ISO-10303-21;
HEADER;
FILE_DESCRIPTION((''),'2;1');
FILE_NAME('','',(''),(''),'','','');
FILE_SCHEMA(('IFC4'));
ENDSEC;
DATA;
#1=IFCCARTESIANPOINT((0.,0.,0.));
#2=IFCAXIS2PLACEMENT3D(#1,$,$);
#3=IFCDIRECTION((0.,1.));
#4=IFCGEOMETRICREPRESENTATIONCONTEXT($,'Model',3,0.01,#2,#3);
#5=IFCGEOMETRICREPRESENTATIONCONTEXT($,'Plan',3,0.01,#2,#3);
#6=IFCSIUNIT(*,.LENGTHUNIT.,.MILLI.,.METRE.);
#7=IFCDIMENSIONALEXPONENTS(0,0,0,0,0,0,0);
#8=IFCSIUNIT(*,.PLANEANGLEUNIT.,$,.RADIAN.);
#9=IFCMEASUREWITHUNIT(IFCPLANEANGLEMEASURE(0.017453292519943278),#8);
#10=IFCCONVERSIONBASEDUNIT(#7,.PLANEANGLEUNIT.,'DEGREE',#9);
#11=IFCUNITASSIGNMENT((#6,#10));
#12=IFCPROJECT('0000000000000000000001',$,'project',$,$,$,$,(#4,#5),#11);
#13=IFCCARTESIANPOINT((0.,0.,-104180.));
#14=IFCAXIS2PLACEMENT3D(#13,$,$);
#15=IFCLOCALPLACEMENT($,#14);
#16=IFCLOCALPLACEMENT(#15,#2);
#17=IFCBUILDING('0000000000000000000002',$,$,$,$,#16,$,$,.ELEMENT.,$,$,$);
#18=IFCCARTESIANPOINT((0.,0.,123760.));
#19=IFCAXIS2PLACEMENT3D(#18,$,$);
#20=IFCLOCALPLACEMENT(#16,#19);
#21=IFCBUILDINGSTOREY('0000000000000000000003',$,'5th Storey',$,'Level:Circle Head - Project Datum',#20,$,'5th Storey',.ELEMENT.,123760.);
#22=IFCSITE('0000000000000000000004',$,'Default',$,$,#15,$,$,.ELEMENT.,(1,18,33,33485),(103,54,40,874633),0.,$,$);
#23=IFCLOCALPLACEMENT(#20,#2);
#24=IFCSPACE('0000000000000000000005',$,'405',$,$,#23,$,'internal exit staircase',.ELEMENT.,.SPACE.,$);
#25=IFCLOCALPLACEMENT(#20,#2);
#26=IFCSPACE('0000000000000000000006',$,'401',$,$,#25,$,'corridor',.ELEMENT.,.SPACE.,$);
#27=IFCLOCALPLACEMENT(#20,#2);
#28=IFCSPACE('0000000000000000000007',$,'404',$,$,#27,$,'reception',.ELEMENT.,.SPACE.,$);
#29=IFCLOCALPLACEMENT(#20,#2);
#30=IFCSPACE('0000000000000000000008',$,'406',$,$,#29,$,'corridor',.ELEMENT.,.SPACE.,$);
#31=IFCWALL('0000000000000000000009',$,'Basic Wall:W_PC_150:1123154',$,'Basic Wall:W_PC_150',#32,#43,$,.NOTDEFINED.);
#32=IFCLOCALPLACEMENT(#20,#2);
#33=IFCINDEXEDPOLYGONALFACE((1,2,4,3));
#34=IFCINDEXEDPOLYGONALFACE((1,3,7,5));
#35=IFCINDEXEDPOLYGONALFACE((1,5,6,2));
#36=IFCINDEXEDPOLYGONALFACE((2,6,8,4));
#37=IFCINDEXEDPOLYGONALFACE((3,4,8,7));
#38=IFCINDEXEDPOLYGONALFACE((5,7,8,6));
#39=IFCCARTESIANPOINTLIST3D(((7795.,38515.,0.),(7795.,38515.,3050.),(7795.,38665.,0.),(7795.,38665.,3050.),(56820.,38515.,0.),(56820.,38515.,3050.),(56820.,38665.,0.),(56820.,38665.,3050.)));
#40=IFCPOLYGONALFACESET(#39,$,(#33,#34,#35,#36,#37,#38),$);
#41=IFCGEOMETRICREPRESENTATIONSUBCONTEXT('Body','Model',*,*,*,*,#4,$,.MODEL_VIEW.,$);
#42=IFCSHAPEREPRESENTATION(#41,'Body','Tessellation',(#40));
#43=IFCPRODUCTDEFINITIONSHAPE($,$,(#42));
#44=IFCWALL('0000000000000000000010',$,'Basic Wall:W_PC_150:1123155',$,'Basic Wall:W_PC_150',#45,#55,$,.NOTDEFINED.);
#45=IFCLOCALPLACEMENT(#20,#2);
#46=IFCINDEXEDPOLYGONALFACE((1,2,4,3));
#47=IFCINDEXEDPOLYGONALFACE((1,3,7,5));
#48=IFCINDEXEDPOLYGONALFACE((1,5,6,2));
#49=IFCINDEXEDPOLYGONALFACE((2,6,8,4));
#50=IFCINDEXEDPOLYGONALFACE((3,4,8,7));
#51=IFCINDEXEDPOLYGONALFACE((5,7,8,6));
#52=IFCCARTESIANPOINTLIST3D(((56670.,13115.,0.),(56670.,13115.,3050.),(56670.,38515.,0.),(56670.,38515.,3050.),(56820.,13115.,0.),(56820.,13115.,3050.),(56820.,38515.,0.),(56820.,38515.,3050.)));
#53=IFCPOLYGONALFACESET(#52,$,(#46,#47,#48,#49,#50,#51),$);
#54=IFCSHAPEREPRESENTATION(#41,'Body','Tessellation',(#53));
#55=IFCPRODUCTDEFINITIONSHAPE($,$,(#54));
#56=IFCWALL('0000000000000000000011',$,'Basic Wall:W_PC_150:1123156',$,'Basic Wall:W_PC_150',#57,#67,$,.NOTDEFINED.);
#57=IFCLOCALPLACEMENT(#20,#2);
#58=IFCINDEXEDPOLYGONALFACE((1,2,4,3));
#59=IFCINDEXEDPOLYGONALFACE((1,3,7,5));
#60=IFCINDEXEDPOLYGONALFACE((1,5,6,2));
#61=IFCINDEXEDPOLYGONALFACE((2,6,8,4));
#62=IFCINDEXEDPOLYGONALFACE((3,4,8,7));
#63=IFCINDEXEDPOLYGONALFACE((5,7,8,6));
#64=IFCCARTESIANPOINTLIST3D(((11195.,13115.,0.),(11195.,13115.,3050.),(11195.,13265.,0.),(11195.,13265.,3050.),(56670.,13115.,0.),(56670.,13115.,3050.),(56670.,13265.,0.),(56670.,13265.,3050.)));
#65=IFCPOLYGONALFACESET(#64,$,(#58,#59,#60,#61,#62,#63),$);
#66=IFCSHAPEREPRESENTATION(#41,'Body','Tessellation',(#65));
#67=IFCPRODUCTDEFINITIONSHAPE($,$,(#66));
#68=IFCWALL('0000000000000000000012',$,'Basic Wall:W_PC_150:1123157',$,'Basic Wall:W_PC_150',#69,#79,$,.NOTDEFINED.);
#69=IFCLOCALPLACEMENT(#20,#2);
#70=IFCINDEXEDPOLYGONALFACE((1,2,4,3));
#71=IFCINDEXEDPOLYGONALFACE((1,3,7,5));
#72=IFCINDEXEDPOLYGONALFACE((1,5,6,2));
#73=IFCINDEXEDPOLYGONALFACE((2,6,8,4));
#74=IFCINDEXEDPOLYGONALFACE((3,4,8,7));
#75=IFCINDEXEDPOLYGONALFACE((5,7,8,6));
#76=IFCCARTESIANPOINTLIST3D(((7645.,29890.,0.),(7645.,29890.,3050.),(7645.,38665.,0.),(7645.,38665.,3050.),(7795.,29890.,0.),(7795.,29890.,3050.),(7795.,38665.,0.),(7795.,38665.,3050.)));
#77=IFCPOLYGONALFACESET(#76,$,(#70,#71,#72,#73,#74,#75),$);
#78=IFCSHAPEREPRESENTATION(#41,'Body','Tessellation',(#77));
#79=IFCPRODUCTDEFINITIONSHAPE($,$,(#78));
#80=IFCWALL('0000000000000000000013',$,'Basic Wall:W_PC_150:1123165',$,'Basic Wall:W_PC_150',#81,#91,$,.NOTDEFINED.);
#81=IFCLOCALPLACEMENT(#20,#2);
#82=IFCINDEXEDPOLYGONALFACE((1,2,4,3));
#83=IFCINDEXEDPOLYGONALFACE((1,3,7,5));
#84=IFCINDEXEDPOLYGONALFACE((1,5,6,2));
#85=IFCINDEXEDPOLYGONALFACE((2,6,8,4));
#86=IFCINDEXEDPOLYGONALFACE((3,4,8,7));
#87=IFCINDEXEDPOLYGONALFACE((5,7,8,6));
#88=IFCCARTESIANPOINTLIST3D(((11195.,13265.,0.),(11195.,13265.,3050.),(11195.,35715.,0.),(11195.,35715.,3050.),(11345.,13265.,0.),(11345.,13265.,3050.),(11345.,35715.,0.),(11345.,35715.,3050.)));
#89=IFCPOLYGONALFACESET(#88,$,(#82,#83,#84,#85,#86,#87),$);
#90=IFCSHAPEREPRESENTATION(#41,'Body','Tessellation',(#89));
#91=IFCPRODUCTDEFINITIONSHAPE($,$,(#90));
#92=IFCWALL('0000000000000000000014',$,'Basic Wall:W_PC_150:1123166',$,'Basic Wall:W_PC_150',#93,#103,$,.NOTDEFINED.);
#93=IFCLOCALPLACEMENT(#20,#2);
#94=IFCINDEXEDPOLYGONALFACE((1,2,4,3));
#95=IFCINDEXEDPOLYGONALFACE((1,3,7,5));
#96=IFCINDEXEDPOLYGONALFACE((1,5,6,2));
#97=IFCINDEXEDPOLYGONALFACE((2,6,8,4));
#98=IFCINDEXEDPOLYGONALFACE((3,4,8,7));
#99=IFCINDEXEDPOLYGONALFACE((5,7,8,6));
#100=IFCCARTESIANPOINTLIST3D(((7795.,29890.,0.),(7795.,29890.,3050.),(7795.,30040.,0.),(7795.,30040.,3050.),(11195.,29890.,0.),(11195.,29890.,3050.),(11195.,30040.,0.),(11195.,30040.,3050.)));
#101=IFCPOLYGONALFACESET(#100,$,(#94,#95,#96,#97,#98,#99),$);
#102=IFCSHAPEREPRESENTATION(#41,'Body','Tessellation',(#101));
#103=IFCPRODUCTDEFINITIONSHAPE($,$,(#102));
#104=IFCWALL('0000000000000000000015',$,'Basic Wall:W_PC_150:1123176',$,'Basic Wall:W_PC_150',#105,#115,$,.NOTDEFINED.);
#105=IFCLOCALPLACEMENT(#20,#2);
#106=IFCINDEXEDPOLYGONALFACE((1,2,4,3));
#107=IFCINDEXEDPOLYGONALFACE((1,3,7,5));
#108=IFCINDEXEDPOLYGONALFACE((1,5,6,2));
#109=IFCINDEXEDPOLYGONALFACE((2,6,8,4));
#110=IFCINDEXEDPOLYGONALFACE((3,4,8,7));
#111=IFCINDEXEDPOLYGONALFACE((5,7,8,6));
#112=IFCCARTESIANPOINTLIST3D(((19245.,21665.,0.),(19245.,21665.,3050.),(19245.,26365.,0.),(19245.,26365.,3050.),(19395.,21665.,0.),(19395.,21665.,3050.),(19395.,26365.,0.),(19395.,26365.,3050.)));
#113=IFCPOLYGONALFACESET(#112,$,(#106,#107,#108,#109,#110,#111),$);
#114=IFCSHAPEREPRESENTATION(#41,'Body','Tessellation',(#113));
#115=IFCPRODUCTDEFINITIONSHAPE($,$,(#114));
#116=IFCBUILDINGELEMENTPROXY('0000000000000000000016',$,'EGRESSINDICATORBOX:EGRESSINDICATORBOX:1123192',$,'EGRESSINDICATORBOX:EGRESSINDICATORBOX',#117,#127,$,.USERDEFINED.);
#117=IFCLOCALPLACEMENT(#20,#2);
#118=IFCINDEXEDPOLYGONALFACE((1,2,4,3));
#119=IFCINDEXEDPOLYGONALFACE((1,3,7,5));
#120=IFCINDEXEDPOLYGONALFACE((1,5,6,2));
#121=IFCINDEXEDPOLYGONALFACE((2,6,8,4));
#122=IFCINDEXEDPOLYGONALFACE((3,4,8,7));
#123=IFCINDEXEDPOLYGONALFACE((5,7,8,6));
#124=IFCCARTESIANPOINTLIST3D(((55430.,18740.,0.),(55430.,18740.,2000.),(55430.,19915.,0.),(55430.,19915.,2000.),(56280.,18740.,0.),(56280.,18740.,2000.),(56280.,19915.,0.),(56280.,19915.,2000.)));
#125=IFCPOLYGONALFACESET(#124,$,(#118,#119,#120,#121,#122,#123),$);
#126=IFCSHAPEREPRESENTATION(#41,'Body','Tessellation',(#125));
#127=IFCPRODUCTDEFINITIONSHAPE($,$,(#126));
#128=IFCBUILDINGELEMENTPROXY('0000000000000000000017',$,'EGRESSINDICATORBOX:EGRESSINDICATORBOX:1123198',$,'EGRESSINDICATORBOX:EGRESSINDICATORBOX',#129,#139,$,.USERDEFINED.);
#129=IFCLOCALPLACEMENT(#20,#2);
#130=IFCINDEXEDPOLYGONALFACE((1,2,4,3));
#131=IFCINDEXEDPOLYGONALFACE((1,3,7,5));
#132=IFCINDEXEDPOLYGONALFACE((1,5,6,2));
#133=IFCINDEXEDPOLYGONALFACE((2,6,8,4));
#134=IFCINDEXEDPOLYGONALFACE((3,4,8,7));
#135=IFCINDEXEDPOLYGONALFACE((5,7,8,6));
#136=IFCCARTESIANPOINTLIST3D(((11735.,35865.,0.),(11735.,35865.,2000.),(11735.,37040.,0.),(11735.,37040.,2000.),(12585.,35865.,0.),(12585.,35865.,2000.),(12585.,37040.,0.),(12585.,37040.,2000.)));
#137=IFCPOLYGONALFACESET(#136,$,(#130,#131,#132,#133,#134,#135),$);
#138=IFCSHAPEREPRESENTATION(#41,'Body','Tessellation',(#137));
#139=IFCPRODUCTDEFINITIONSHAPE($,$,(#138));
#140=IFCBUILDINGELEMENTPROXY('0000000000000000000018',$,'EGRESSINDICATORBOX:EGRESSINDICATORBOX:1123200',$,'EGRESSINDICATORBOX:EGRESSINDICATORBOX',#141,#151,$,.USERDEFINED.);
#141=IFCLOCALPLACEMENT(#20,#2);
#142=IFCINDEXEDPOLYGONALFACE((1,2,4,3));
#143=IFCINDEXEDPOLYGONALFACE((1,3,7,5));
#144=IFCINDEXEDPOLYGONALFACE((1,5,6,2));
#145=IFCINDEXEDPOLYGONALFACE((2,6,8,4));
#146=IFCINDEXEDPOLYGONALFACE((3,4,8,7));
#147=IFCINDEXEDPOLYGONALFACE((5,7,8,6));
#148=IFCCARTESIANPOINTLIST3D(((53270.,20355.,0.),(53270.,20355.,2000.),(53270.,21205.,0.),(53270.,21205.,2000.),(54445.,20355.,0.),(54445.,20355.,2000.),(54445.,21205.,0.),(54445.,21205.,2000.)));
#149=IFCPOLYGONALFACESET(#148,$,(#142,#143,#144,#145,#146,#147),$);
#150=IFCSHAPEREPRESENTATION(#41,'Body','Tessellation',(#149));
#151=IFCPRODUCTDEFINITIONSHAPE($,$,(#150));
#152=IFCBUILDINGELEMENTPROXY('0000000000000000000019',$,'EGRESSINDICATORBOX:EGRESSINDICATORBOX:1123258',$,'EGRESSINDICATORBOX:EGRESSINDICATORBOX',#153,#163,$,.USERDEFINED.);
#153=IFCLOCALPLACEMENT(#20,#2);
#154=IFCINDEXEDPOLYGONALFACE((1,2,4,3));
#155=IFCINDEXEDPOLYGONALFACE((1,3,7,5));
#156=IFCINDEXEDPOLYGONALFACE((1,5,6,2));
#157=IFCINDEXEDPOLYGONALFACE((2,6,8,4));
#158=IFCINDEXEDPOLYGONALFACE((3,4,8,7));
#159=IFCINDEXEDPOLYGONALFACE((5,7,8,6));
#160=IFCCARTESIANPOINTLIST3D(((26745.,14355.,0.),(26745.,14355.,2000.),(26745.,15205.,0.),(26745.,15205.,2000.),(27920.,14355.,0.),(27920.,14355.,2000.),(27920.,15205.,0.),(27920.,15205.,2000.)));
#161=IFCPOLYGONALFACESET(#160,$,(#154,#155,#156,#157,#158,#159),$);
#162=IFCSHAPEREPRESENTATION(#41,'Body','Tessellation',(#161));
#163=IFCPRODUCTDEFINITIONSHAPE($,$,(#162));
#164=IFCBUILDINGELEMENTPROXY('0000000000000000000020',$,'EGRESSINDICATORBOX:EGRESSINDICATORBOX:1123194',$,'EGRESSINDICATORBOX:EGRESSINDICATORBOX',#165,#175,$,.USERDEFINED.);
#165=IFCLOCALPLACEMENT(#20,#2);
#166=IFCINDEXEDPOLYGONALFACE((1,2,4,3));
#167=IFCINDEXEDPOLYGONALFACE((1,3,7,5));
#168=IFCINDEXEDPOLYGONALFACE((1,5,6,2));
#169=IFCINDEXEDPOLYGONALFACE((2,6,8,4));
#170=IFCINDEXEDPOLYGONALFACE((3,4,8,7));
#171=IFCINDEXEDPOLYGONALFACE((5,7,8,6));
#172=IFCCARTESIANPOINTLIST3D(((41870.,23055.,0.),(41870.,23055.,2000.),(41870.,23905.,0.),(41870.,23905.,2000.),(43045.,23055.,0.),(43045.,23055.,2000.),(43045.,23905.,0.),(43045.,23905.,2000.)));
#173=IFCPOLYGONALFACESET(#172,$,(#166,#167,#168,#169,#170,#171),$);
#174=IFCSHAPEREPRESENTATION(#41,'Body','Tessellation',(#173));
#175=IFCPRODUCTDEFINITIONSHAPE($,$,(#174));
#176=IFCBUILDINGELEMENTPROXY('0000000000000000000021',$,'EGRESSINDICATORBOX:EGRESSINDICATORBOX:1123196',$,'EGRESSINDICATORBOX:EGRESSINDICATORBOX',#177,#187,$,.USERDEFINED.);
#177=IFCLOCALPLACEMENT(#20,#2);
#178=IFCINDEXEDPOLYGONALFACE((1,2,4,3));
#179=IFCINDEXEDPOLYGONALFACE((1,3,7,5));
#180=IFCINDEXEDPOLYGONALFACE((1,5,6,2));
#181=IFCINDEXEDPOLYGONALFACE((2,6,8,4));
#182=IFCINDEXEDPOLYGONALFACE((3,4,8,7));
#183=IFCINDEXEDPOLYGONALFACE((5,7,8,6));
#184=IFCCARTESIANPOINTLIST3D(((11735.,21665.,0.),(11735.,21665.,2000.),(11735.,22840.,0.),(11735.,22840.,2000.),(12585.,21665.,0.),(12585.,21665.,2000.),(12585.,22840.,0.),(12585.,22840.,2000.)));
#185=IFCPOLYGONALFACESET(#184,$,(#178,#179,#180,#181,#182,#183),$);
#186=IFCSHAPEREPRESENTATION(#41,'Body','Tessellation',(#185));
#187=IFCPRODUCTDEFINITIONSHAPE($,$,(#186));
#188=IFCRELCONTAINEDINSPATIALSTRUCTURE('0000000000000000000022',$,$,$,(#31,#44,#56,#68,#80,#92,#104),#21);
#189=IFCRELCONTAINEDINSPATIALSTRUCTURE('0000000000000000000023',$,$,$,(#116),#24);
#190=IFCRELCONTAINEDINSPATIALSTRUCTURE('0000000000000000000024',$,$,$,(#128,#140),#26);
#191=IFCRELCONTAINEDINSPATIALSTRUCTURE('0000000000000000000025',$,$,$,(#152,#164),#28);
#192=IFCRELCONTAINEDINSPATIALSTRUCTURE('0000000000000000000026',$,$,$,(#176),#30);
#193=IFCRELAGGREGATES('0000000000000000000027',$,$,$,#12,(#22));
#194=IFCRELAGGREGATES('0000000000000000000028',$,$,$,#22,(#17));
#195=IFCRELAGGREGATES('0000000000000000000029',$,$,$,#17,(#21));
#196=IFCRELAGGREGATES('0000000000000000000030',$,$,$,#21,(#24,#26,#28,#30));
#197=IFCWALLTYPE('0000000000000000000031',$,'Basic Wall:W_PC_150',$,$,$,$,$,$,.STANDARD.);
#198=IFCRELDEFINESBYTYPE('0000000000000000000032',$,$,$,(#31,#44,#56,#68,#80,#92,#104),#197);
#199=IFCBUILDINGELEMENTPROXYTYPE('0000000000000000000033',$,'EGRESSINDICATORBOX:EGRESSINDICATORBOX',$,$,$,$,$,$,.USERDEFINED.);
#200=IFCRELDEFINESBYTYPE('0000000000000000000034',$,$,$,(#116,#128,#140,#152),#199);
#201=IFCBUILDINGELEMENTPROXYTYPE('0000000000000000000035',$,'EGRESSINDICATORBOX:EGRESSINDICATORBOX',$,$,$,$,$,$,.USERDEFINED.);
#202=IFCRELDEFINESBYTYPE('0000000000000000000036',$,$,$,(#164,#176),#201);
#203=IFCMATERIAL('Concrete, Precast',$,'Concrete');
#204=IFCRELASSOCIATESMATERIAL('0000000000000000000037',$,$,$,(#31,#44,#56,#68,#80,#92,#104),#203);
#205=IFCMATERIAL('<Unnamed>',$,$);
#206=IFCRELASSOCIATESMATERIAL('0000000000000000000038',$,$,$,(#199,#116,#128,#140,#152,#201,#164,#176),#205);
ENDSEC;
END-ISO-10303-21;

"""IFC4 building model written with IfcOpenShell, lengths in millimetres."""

from ifc_helpers import new_model, entity, si_unit, converted_unit, direction, frame, origin, place, context, subcontext, project, spatial, indexed_curve, outline, extrude, source, transform, mapped, material, type_object, type_shapes, element, save


model = new_model("IFC4")

# Units and contexts
model_context = context("Model", 3, precision=0.01, world=origin(), true_north=direction((0.0, 1.0)))
plan_context = context("Plan", 3, precision=0.01, world=origin(), true_north=direction((0.0, 1.0)))
body_context = subcontext(model_context, "Body", "Model", "MODEL_VIEW")
ifc_project = project(units=[si_unit("LENGTHUNIT", "METRE", prefix="MILLI"), converted_unit("PLANEANGLEUNIT", "DEGREE", entity("IfcPlaneAngleMeasure", 0.017453292519943278), si_unit("PLANEANGLEUNIT", "RADIAN"), dimensions=[0, 0, 0, 0, 0, 0, 0])], contexts=[model_context, plan_context])

# Site, building, storey
site_placement = place(None, frame((0.0, 0.0, -104180.0)))
site = spatial("IfcSite", under=ifc_project, at=site_placement, Name="Default", CompositionType="ELEMENT", RefLatitude=(1, 18, 33, 33485), RefLongitude=(103, 54, 40, 874633), RefElevation=0.0)
building_placement = place(site_placement, origin())
building = spatial("IfcBuilding", under=site, at=building_placement, CompositionType="ELEMENT")
storey_placement = place(building_placement, frame((0.0, 0.0, 123760.0)))
storey = spatial("IfcBuildingStorey", under=building, at=storey_placement, Name="5th Storey", ObjectType="Level:Circle Head - Project Datum", LongName="5th Storey", CompositionType="ELEMENT", Elevation=123760.0)

# Shared definitions
ifc_material_1 = material(Name="Concrete, Precast", Category="Concrete")

# Walls
wall_type = type_object("IfcWallType", Name="Basic Wall:W_PC_150", PredefinedType="STANDARD")
wall_1_placement = place(storey_placement, frame((56820.0, 38590.0, 0.0), z_axis=(0.0, 0.0, 1.0), x_axis=(-1.0, 0.0, 0.0)))
element("IfcWall", 1, at=wall_1_placement, inside=storey, type_object=wall_type, material=ifc_material_1, Name="Basic Wall:W_PC_150:1123154", ObjectType="Basic Wall:W_PC_150", PredefinedType="NOTDEFINED", context=body_context, shape_type="SweptSolid", body=[
    extrude(outline(indexed_curve([(49025.0, 75.0), (0.0, 75.0), (0.0, -75.0), (49025.0, -75.0), (49025.0, 75.0)], self_intersect=False)), origin(), (0.0, 0.0, 1.0), 3050.0),
])
wall_2_placement = place(storey_placement, frame((56745.0, 13115.0, 0.0), z_axis=(0.0, 0.0, 1.0), x_axis=(0.0, 1.0, 0.0)))
element("IfcWall", 2, at=wall_2_placement, inside=storey, type_object=wall_type, material=ifc_material_1, Name="Basic Wall:W_PC_150:1123155", ObjectType="Basic Wall:W_PC_150", PredefinedType="NOTDEFINED", context=body_context, shape_type="SweptSolid", body=[
    extrude(outline(indexed_curve([(25400.0, 75.0), (0.0, 75.0), (0.0, -75.0), (25400.0, -75.0), (25400.0, 75.0)], self_intersect=False)), origin(), (0.0, 0.0, 1.0), 3050.0),
])
wall_3_placement = place(storey_placement, frame((11195.0, 13190.0, 0.0)))
element("IfcWall", 3, at=wall_3_placement, inside=storey, type_object=wall_type, material=ifc_material_1, Name="Basic Wall:W_PC_150:1123156", ObjectType="Basic Wall:W_PC_150", PredefinedType="NOTDEFINED", context=body_context, shape_type="SweptSolid", body=[
    extrude(outline(indexed_curve([(45475.0, 75.0), (0.0, 75.0), (0.0, -75.0), (45475.0, -75.0), (45475.0, 75.0)], self_intersect=False)), origin(), (0.0, 0.0, 1.0), 3050.0),
])
wall_4_placement = place(storey_placement, frame((7720.0, 38665.0, 0.0), z_axis=(0.0, 0.0, 1.0), x_axis=(0.0, -1.0, 0.0)))
element("IfcWall", 4, at=wall_4_placement, inside=storey, type_object=wall_type, material=ifc_material_1, Name="Basic Wall:W_PC_150:1123157", ObjectType="Basic Wall:W_PC_150", PredefinedType="NOTDEFINED", context=body_context, shape_type="SweptSolid", body=[
    extrude(outline(indexed_curve([(8775.0, 75.0), (0.0, 75.0), (0.0, -75.0), (8775.0, -75.0), (8775.0, 75.0)], self_intersect=False)), origin(), (0.0, 0.0, 1.0), 3050.0),
])
wall_5_placement = place(storey_placement, frame((11270.0, 35715.0, 0.0), z_axis=(0.0, 0.0, 1.0), x_axis=(0.0, -1.0, 0.0)))
element("IfcWall", 5, at=wall_5_placement, inside=storey, type_object=wall_type, material=ifc_material_1, Name="Basic Wall:W_PC_150:1123165", ObjectType="Basic Wall:W_PC_150", PredefinedType="NOTDEFINED", context=body_context, shape_type="SweptSolid", body=[
    extrude(outline(indexed_curve([(22450.0, 75.0), (0.0, 75.0), (0.0, -75.0), (22450.0, -75.0), (22450.0, 75.0)], self_intersect=False)), origin(), (0.0, 0.0, 1.0), 3050.0),
])
wall_6_placement = place(storey_placement, frame((7795.0, 29965.0, 0.0)))
element("IfcWall", 6, at=wall_6_placement, inside=storey, type_object=wall_type, material=ifc_material_1, Name="Basic Wall:W_PC_150:1123166", ObjectType="Basic Wall:W_PC_150", PredefinedType="NOTDEFINED", context=body_context, shape_type="SweptSolid", body=[
    extrude(outline(indexed_curve([(3400.0, 75.0), (0.0, 75.0), (0.0, -75.0), (3400.0, -75.0), (3400.0, 75.0)], self_intersect=False)), origin(), (0.0, 0.0, 1.0), 3050.0),
])
wall_7_placement = place(storey_placement, frame((19320.0, 21665.0, 0.0), z_axis=(0.0, 0.0, 1.0), x_axis=(0.0, 1.0, 0.0)))
element("IfcWall", 7, at=wall_7_placement, inside=storey, type_object=wall_type, material=ifc_material_1, Name="Basic Wall:W_PC_150:1123176", ObjectType="Basic Wall:W_PC_150", PredefinedType="NOTDEFINED", context=body_context, shape_type="SweptSolid", body=[
    extrude(outline(indexed_curve([(4700.0, 75.0), (0.0, 75.0), (0.0, -75.0), (4700.0, -75.0), (4700.0, 75.0)], self_intersect=False)), origin(), (0.0, 0.0, 1.0), 3050.0),
])

# Shared definitions
space_1_placement = place(storey_placement, origin())
space_1 = spatial("IfcSpace", under=storey, at=space_1_placement, Name="405", LongName="internal exit staircase", CompositionType="ELEMENT", PredefinedType="SPACE")

# Building element proxy
ifc_material_2 = material(Name="<Unnamed>")
building_element_proxy_type_1 = type_object("IfcBuildingElementProxyType", Name="EGRESSINDICATORBOX:EGRESSINDICATORBOX", PredefinedType="USERDEFINED", material=ifc_material_2)
shared_shape_1 = source(origin(), body_context, "Body", "SweptSolid", [
    extrude(outline(indexed_curve([(-587.5, -425.0), (587.5, -425.0), (587.5, 425.0), (-587.5, 425.0), (-587.5, -425.0)], self_intersect=False)), frame((0.0, 0.0, 0.0), z_axis=(0.0, 0.0, 1.0), x_axis=(0.0, 1.0, 0.0)), (0.0, 0.0, 1.0), 2000.0),
])
type_shapes(building_element_proxy_type_1, [shared_shape_1])
proxy_1_placement = place(space_1_placement, frame((55855.0, 19327.5, 0.0)))
element("IfcBuildingElementProxy", 8, at=proxy_1_placement, inside=space_1, type_object=building_element_proxy_type_1, material=ifc_material_2, Name="EGRESSINDICATORBOX:EGRESSINDICATORBOX:1123192", ObjectType="EGRESSINDICATORBOX:EGRESSINDICATORBOX", PredefinedType="USERDEFINED", context=body_context, shape_type="MappedRepresentation", body=[
    mapped(shared_shape_1, transform((0.0, 0.0, 0.0), scale=1.0)),
])

# Shared definitions
space_2_placement = place(storey_placement, origin())
space_2 = spatial("IfcSpace", under=storey, at=space_2_placement, Name="401", LongName="corridor", CompositionType="ELEMENT", PredefinedType="SPACE")

# Building element proxies
for number, where, z_axis, x_axis, name in (
    (9, (12160.0, 36452.5, 0.0), (0.0, 0.0, 1.0), (-1.0, 0.0, 0.0), "EGRESSINDICATORBOX:EGRESSINDICATORBOX:1123198"),
    (10, (53857.5, 20780.0, 0.0), (0.0, 0.0, 1.0), (0.0, 1.0, 0.0), "EGRESSINDICATORBOX:EGRESSINDICATORBOX:1123200"),
):
    element("IfcBuildingElementProxy", number, at=place(space_2_placement, frame(where, z_axis=z_axis, x_axis=x_axis)), inside=space_2, type_object=building_element_proxy_type_1, material=ifc_material_2, Name=name, ObjectType="EGRESSINDICATORBOX:EGRESSINDICATORBOX", PredefinedType="USERDEFINED", context=body_context, shape_type="MappedRepresentation", body=[
        mapped(shared_shape_1, transform((0.0, 0.0, 0.0), scale=1.0)),
    ])

# Shared definitions
space_3_placement = place(storey_placement, origin())
space_3 = spatial("IfcSpace", under=storey, at=space_3_placement, Name="404", LongName="reception", CompositionType="ELEMENT", PredefinedType="SPACE")

# Building element proxies
proxy_2_placement = place(space_3_placement, frame((27332.5, 14780.0, 0.0), z_axis=(0.0, 0.0, 1.0), x_axis=(0.0, 1.0, 0.0)))
element("IfcBuildingElementProxy", 11, at=proxy_2_placement, inside=space_3, type_object=building_element_proxy_type_1, material=ifc_material_2, Name="EGRESSINDICATORBOX:EGRESSINDICATORBOX:1123258", ObjectType="EGRESSINDICATORBOX:EGRESSINDICATORBOX", PredefinedType="USERDEFINED", context=body_context, shape_type="MappedRepresentation", body=[
    mapped(shared_shape_1, transform((0.0, 0.0, 0.0), scale=1.0)),
])
building_element_proxy_type_2 = type_object("IfcBuildingElementProxyType", Name="EGRESSINDICATORBOX:EGRESSINDICATORBOX", PredefinedType="USERDEFINED", material=ifc_material_2)
shared_shape_2 = source(origin(), body_context, "Body", "SweptSolid", [
    extrude(outline(indexed_curve([(-425.0, -587.5), (425.0, -587.5), (425.0, 587.5), (-425.0, 587.5), (-425.0, -587.5)], self_intersect=False)), frame((0.0, 0.0, 0.0), z_axis=(0.0, 0.0, 1.0), x_axis=(-1.0, 0.0, 0.0)), (0.0, 0.0, 1.0), 2000.0),
])
type_shapes(building_element_proxy_type_2, [shared_shape_2])
proxy_3_placement = place(space_3_placement, frame((42457.5, 23480.0, 0.0), z_axis=(0.0, 0.0, 1.0), x_axis=(0.0, -1.0, 0.0)))
element("IfcBuildingElementProxy", 12, at=proxy_3_placement, inside=space_3, type_object=building_element_proxy_type_2, material=ifc_material_2, Name="EGRESSINDICATORBOX:EGRESSINDICATORBOX:1123194", ObjectType="EGRESSINDICATORBOX:EGRESSINDICATORBOX", PredefinedType="USERDEFINED", context=body_context, shape_type="MappedRepresentation", body=[
    mapped(shared_shape_2, transform((0.0, 0.0, 0.0), scale=1.0)),
])

# Shared definitions
space_4_placement = place(storey_placement, origin())
space_4 = spatial("IfcSpace", under=storey, at=space_4_placement, Name="406", LongName="corridor", CompositionType="ELEMENT", PredefinedType="SPACE")

# Building element proxy
proxy_4_placement = place(space_4_placement, frame((12160.0, 22252.5, 0.0)))
element("IfcBuildingElementProxy", 13, at=proxy_4_placement, inside=space_4, type_object=building_element_proxy_type_2, material=ifc_material_2, Name="EGRESSINDICATORBOX:EGRESSINDICATORBOX:1123196", ObjectType="EGRESSINDICATORBOX:EGRESSINDICATORBOX", PredefinedType="USERDEFINED", context=body_context, shape_type="MappedRepresentation", body=[
    mapped(shared_shape_2, transform((0.0, 0.0, 0.0), scale=1.0)),
])

save(model, "model.ifc")
